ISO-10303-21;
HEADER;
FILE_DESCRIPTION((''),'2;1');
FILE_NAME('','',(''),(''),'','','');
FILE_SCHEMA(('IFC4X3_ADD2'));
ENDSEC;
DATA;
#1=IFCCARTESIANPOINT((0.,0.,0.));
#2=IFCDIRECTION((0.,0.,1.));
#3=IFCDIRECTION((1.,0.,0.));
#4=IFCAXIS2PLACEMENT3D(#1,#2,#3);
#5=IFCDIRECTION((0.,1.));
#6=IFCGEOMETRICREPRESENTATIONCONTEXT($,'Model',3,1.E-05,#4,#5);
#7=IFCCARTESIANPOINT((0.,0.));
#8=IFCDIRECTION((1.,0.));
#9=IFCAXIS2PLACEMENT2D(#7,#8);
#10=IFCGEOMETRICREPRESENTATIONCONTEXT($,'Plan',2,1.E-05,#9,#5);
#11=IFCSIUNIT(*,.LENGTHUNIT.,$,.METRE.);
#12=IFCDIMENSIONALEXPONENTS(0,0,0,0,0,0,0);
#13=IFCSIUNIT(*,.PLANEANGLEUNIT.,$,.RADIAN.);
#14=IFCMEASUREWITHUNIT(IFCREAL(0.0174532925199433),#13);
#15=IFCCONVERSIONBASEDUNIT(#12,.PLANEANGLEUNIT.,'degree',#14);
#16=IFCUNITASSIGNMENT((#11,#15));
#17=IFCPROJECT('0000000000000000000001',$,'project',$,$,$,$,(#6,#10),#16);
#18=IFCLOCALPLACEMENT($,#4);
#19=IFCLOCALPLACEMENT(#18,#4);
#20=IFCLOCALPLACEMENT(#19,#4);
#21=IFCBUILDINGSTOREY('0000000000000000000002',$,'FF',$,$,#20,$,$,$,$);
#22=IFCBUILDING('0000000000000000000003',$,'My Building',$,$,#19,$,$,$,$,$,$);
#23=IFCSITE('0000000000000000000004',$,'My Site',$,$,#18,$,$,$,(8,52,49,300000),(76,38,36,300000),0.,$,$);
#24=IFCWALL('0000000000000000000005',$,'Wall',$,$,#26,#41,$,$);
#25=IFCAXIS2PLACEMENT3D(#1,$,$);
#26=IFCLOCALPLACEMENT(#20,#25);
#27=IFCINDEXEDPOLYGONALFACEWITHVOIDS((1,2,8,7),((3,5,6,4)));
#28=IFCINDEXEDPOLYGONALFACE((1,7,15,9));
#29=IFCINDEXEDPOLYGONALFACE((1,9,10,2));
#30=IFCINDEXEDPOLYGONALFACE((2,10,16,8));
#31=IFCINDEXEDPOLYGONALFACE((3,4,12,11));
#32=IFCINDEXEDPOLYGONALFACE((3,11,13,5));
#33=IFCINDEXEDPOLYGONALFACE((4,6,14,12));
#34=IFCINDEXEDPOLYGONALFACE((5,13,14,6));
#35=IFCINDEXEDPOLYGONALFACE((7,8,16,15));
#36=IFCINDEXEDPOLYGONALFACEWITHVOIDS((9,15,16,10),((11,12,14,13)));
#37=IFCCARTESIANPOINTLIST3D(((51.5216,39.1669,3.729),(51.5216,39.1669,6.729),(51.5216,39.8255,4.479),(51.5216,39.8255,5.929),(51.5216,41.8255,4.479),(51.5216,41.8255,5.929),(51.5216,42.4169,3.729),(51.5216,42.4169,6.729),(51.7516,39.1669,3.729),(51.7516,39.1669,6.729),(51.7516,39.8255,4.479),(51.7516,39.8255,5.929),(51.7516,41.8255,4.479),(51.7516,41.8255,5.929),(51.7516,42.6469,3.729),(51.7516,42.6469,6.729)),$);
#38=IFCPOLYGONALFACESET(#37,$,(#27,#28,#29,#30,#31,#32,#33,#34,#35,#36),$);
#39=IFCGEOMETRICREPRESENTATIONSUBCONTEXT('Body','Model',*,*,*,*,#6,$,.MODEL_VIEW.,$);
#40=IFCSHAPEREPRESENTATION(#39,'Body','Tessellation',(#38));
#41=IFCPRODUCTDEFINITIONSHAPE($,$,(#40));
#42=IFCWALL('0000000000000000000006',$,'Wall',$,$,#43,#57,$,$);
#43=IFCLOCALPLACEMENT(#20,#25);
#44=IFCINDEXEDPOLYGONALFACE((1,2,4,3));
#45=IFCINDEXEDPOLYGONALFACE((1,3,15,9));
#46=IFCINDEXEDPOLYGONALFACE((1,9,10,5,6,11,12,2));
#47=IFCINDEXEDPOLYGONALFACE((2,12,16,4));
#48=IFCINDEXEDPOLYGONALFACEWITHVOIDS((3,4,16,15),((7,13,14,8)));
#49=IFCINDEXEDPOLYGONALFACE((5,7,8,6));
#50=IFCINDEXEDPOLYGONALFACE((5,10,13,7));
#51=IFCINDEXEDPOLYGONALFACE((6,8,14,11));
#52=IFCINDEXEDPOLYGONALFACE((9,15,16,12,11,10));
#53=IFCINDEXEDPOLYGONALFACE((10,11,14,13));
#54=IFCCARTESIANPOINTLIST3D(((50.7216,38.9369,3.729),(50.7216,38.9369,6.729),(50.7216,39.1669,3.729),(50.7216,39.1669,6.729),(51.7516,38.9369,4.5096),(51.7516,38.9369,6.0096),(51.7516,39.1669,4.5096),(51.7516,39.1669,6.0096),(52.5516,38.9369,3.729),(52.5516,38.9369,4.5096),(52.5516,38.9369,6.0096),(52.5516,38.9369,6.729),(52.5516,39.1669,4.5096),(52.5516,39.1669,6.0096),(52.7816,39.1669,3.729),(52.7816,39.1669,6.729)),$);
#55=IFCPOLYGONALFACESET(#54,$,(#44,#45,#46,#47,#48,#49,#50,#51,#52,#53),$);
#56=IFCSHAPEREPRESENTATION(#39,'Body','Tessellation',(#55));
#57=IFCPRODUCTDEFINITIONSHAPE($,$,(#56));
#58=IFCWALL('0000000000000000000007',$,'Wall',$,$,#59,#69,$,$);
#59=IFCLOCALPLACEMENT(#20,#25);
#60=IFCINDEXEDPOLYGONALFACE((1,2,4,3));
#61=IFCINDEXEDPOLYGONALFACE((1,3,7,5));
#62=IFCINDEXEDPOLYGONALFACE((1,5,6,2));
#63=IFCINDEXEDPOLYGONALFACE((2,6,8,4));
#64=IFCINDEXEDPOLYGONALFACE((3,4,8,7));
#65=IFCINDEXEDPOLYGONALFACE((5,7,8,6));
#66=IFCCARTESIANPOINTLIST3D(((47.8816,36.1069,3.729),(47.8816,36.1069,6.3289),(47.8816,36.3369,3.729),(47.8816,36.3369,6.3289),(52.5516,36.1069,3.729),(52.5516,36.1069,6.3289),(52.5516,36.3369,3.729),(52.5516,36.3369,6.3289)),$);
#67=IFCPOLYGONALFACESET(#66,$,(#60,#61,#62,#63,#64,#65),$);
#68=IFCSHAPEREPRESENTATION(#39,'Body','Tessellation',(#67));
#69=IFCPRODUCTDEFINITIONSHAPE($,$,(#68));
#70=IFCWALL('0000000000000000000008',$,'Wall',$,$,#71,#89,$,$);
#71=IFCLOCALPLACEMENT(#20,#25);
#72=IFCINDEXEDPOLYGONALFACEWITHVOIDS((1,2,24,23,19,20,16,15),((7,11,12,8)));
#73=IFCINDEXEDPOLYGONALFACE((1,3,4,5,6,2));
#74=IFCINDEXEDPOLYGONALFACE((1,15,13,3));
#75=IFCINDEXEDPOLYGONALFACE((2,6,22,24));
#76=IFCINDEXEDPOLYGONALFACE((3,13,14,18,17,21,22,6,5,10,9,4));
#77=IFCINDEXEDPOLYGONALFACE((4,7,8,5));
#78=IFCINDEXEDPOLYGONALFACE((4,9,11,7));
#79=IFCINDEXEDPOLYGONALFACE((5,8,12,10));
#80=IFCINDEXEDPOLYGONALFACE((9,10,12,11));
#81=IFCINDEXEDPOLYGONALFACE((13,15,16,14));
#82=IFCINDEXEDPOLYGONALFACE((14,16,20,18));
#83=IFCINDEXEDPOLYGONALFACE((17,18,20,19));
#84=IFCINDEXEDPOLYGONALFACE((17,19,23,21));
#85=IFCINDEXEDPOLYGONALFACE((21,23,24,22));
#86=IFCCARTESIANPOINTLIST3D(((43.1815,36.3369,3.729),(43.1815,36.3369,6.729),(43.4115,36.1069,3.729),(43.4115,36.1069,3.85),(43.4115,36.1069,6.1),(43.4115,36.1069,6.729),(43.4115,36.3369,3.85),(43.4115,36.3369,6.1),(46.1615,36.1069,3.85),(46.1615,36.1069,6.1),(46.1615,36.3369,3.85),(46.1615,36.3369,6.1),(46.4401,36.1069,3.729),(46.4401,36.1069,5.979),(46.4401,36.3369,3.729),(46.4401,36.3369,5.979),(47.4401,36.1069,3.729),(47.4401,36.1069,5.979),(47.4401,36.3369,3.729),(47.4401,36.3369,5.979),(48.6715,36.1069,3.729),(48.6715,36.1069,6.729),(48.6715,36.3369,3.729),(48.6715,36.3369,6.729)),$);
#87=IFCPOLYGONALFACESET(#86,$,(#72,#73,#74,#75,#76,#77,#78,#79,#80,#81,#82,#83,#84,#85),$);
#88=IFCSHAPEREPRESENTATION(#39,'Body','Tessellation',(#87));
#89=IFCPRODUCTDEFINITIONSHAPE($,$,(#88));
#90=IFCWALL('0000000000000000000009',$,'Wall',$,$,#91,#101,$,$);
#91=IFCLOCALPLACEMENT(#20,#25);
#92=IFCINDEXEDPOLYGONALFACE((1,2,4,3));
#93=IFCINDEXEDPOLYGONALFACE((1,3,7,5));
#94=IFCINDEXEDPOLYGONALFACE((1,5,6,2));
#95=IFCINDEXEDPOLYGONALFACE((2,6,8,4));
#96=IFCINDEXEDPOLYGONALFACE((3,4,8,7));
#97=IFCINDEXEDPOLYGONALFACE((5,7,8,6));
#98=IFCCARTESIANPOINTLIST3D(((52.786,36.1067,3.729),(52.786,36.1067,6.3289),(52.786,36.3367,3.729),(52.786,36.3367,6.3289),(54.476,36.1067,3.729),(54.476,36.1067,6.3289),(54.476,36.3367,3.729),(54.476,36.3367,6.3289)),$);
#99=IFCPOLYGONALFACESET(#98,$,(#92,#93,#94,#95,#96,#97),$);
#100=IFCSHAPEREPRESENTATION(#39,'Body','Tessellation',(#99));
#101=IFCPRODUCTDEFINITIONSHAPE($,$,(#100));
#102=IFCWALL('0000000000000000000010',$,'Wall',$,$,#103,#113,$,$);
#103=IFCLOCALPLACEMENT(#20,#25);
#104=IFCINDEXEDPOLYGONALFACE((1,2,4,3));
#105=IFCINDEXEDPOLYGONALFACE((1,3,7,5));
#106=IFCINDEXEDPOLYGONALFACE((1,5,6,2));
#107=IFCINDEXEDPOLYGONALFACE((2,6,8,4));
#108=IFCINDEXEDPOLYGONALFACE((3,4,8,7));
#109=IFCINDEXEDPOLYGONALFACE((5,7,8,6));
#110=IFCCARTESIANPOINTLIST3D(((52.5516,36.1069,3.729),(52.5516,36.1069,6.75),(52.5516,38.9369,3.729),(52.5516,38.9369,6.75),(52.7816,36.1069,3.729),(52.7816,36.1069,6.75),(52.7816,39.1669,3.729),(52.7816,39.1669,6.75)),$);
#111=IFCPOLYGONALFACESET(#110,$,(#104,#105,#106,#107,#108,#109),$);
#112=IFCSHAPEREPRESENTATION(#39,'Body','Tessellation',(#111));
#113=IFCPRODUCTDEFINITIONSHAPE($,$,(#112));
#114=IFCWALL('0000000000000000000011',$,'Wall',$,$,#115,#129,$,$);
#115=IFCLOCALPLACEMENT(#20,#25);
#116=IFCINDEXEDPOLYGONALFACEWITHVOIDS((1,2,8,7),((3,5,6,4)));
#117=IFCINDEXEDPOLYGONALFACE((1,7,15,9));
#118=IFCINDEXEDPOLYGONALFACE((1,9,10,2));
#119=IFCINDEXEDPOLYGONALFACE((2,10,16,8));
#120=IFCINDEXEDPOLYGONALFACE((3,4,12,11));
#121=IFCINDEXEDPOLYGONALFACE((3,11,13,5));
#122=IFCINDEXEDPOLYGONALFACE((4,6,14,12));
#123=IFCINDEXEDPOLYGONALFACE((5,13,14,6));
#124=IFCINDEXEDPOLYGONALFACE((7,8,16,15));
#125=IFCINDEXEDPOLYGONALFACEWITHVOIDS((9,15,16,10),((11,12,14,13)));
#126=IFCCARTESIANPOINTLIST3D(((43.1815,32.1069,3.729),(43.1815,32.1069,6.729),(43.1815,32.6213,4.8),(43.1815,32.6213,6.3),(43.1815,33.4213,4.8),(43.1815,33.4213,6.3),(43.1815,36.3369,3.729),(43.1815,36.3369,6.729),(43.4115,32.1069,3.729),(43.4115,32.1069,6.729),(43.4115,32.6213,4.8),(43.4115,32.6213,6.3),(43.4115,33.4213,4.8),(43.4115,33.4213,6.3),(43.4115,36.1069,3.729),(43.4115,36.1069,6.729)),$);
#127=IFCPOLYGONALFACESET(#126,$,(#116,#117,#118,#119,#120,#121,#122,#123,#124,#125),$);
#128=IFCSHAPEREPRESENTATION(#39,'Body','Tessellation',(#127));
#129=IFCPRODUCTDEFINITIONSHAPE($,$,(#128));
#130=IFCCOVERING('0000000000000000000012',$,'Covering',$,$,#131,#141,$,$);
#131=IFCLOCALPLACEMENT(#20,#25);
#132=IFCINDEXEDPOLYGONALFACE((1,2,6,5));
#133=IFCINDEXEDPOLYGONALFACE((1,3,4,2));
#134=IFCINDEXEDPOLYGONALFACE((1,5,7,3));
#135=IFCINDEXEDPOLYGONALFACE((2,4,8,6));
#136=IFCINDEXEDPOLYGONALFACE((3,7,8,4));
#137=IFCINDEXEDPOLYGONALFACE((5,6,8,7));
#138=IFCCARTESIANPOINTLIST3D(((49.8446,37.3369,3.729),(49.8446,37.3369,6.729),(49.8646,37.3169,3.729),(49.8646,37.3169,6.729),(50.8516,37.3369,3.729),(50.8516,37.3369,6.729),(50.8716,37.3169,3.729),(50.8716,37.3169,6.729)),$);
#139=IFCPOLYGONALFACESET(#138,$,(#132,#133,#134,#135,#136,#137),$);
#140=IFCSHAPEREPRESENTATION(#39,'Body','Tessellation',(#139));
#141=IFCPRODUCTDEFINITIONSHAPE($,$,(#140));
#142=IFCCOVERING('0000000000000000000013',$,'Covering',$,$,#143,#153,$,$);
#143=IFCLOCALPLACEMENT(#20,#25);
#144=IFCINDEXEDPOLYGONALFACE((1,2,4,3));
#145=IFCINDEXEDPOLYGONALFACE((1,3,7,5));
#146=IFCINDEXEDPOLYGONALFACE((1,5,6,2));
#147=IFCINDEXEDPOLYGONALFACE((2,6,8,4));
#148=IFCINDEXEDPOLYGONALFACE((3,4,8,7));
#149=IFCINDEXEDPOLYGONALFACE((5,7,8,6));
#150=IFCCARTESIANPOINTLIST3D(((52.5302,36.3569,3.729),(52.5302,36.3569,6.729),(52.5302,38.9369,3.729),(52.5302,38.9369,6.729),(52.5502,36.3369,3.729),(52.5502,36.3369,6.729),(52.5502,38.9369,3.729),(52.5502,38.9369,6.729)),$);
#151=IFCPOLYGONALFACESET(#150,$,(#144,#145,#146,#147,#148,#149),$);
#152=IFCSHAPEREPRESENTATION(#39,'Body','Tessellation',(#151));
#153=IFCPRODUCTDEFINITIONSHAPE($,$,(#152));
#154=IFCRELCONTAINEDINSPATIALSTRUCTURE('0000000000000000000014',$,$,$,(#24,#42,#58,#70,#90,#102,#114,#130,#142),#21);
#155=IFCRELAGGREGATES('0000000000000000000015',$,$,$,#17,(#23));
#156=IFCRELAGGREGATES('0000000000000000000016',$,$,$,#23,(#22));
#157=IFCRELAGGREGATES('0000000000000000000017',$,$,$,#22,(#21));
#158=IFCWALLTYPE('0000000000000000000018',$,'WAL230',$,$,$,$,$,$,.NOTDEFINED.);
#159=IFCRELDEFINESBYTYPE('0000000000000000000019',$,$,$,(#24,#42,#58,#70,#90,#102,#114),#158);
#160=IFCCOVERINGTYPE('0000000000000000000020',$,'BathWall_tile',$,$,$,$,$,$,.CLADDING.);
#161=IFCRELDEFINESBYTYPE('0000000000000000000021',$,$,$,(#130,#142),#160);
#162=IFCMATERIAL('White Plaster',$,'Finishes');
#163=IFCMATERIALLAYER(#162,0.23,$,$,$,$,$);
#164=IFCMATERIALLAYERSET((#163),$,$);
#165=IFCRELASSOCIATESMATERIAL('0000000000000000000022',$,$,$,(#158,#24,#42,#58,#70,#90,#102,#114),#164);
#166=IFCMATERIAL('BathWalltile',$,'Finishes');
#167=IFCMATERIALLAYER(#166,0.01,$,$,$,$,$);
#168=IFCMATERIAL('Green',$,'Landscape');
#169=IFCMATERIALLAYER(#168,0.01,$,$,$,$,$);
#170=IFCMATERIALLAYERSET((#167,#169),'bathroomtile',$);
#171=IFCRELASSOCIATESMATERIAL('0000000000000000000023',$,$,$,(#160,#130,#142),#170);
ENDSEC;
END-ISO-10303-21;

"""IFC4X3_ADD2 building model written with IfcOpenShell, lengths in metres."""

from ifc_helpers import new_model, entity, si_unit, converted_unit, direction, frame, origin_with_axes, origin_2d_with_axis, place, context, subcontext, project, spatial, line, indexed_curve, outline, extrude, source, transform, mapped, material, layer, layer_set, layer_usage, type_object, element, save


model = new_model("IFC4X3_ADD2")

# Units and contexts
model_context = context("Model", 3, precision=1e-05, world=origin_with_axes(), true_north=direction((0.0, 1.0)))
plan_context = context("Plan", 2, precision=1e-05, world=origin_2d_with_axis(), true_north=direction((0.0, 1.0)))
body_context_1 = subcontext(model_context, "Body", "Model", "MODEL_VIEW")
ifc_project = project(units=[si_unit("LENGTHUNIT", "METRE"), converted_unit("PLANEANGLEUNIT", "degree", entity("IfcReal", 0.0174532925199433), si_unit("PLANEANGLEUNIT", "RADIAN"), dimensions=[0, 0, 0, 0, 0, 0, 0])], contexts=[model_context, plan_context])

# Site, building, storey
site_placement = place(None, origin_with_axes())
site = spatial("IfcSite", under=ifc_project, at=site_placement, Name="My Site", RefLatitude=(8, 52, 49, 300000), RefLongitude=(76, 38, 36, 300000), RefElevation=0.0)
building_placement = place(site_placement, origin_with_axes())
building = spatial("IfcBuilding", under=site, at=building_placement, Name="My Building")
storey_placement = place(building_placement, origin_with_axes())
storey = spatial("IfcBuildingStorey", under=building, at=storey_placement, Name="FF")

# Walls, openings
ifc_material_1 = material(Name="White Plaster", Category="Finishes")
ifc_layer_1 = layer(ifc_material_1, 0.23)
ifc_layer_set_1 = layer_set([ifc_layer_1])
ifc_layer_usage_1 = layer_usage(ifc_layer_set_1, "AXIS2", "POSITIVE", 0.0)
wall_type_1 = type_object("IfcWallType", Name="WAL230", PredefinedType="NOTDEFINED", material=ifc_layer_set_1)
wall_1_placement = place(storey_placement, frame((51.7516, 39.1669, 3.729), z_axis=(0.0, 0.0, 1.0), x_axis=(0.0, 1.0, 0.0)))
wall_1 = element("IfcWall", 1, at=wall_1_placement, inside=storey, type_object=wall_type_1, material=ifc_layer_usage_1, Name="Wall", context=body_context_1, shape_type="SweptSolid", body=[
    extrude(outline(indexed_curve([(0.0, 0.0), (0.0, 0.23), (3.25, 0.23), (3.48, 0.0)], segments=[line(1, 2, 3, 4, 1)])), origin_with_axes(), (0.0, 0.0, 1.0), 3.0),
])
shared_shape_1 = source(origin_with_axes(), body_context_1, "Body", "SweptSolid", [
    extrude(outline(indexed_curve([(0.0, 0.0), (2.0, 0.0), (2.0, 1.45), (0.0, 1.45)], segments=[line(1, 2, 3, 4, 1)])), frame((0.0, -0.6, 0.0), z_axis=(0.0, -1.0, 0.0), x_axis=(1.0, 0.0, 0.0)), (0.0, 0.0, -1.0), 1.2),
])
opening_1_placement = place(wall_1_placement, frame((0.6586, 0.0, 0.75), z_axis=(0.0, 0.0, 1.0), x_axis=(1.0, 0.0, 0.0)))
element("IfcOpeningElement", 2, at=opening_1_placement, cuts=wall_1, PredefinedType="OPENING", context=body_context_1, shape_type="MappedRepresentation", body=[
    mapped(shared_shape_1, transform((0.0, 0.0, 0.0), x_axis=(1.0, 0.0, 0.0), y_axis=(0.0, 1.0, 0.0), z_axis=(0.0, 0.0, 1.0), scale=1.0)),
])
ifc_layer_usage_2 = layer_usage(ifc_layer_set_1, "AXIS2", "POSITIVE", 0.0)
wall_2_placement = place(storey_placement, frame((52.5516, 39.1669, 3.729), z_axis=(0.0, 0.0, 1.0), x_axis=(-1.0, 0.0, 0.0)))
wall_2 = element("IfcWall", 3, at=wall_2_placement, inside=storey, type_object=wall_type_1, material=ifc_layer_usage_2, Name="Wall", context=body_context_1, shape_type="SweptSolid", body=[
    extrude(outline(indexed_curve([(-0.23, 0.0), (0.0, 0.23), (1.83, 0.23), (1.83, 0.0)], segments=[line(1, 2, 3, 4, 1)])), origin_with_axes(), (0.0, 0.0, 1.0), 3.0),
])
shared_shape_2 = source(origin_with_axes(), body_context_1, "Body", "SweptSolid", [
    extrude(outline(indexed_curve([(0.0, 0.0), (0.8, 0.0), (0.8, 1.5), (0.0, 1.5)], segments=[line(1, 2, 3, 4, 1)])), frame((0.0, -0.6, 0.0), z_axis=(0.0, -1.0, 0.0), x_axis=(1.0, 0.0, 0.0)), (0.0, 0.0, -1.0), 1.2),
])
opening_2_placement = place(wall_2_placement, frame((0.8, 0.23, 0.7806), z_axis=(0.0, 0.0, 1.0), x_axis=(-1.0, 0.0, 0.0)))
element("IfcOpeningElement", 4, at=opening_2_placement, cuts=wall_2, PredefinedType="OPENING", context=body_context_1, shape_type="MappedRepresentation", body=[
    mapped(shared_shape_2, transform((0.0, 0.0, 0.0), x_axis=(1.0, 0.0, 0.0), y_axis=(0.0, 1.0, 0.0), z_axis=(0.0, 0.0, 1.0), scale=1.0)),
])

# Wall
ifc_layer_usage_3 = layer_usage(ifc_layer_set_1, "AXIS2", "NEGATIVE", 0.0)
wall_3_placement = place(storey_placement, frame((52.5516, 36.1069, 3.729), z_axis=(0.0, 0.0, 1.0), x_axis=(-1.0, 0.0, 0.0)))
element("IfcWall", 5, at=wall_3_placement, inside=storey, type_object=wall_type_1, material=ifc_layer_usage_3, Name="Wall", context=body_context_1, shape_type="SweptSolid", body=[
    extrude(outline(indexed_curve([(0.0, -0.23), (0.0, 0.0), (4.67, 0.0), (4.67, -0.23)], segments=[line(1, 2, 3, 4, 1)])), origin_with_axes(), (0.0, 0.0, 1.0), 2.5999),
])

# Wall, openings
ifc_layer_usage_4 = layer_usage(ifc_layer_set_1, "AXIS2", "POSITIVE", 0.0)
wall_4_placement = place(storey_placement, frame((48.6715, 36.3369, 3.729), z_axis=(0.0, 0.0, 1.0), x_axis=(-1.0, 0.0, 0.0)))
wall_4 = element("IfcWall", 6, at=wall_4_placement, inside=storey, type_object=wall_type_1, material=ifc_layer_usage_4, Name="Wall", context=body_context_1, shape_type="SweptSolid", body=[
    extrude(outline(indexed_curve([(0.0, 0.0), (0.0, 0.23), (5.26, 0.23), (5.49, 0.0)], segments=[line(1, 2, 3, 4, 1)])), origin_with_axes(), (0.0, 0.0, 1.0), 3.0),
])
shared_shape_3 = source(origin_with_axes(), body_context_1, "Body", "SweptSolid", [
    extrude(outline(indexed_curve([(0.0, 0.0), (1.0, 0.0), (1.0, 2.25), (0.0, 2.25)], segments=[line(1, 2, 3, 4, 1)])), frame((0.0, -0.6, 0.0), z_axis=(0.0, -1.0, 0.0), x_axis=(1.0, 0.0, 0.0)), (0.0, 0.0, -1.0), 1.2),
])
opening_3_placement = place(wall_4_placement, frame((2.2314, 0.23, 0.0), z_axis=(0.0, 0.0, 1.0), x_axis=(-1.0, 0.0, 0.0)))
element("IfcOpeningElement", 7, at=opening_3_placement, cuts=wall_4, PredefinedType="OPENING", context=body_context_1, shape_type="MappedRepresentation", body=[
    mapped(shared_shape_3, transform((0.0, 0.0, 0.0), x_axis=(1.0, 0.0, 0.0), y_axis=(0.0, 1.0, 0.0), z_axis=(0.0, 0.0, 1.0), scale=1.0)),
])
shared_shape_4 = source(origin_with_axes(), body_context_1, "Body", "SweptSolid", [
    extrude(outline(indexed_curve([(0.0, 0.0), (2.75, 0.0), (2.75, 2.25), (0.0, 2.25)], segments=[line(1, 2, 3, 4, 1)])), frame((0.0, -0.6, 0.0), z_axis=(0.0, -1.0, 0.0), x_axis=(1.0, 0.0, 0.0)), (0.0, 0.0, -1.0), 1.2),
])
opening_4_placement = place(wall_4_placement, frame((2.51, 0.0, 0.121), z_axis=(0.0, 0.0, 1.0), x_axis=(1.0, 0.0, 0.0)))
element("IfcOpeningElement", 8, at=opening_4_placement, cuts=wall_4, PredefinedType="OPENING", context=body_context_1, shape_type="MappedRepresentation", body=[
    mapped(shared_shape_4, transform((0.0, 0.0, 0.0), x_axis=(1.0, 0.0, 0.0), y_axis=(0.0, 1.0, 0.0), z_axis=(0.0, 0.0, 1.0), scale=1.0)),
])

# Walls
ifc_layer_usage_5 = layer_usage(ifc_layer_set_1, "AXIS2", "POSITIVE", 0.0)
wall_5_placement = place(storey_placement, frame((54.476, 36.3367, 3.729), z_axis=(0.0, 0.0, 1.0), x_axis=(-1.0, 0.0, 0.0)))
element("IfcWall", 9, at=wall_5_placement, inside=storey, type_object=wall_type_1, material=ifc_layer_usage_5, Name="Wall", context=body_context_1, shape_type="SweptSolid", body=[
    extrude(outline(indexed_curve([(0.0, 0.0), (0.0, 0.23), (1.69, 0.23), (1.69, 0.0)], segments=[line(1, 2, 3, 4, 1)])), origin_with_axes(), (0.0, 0.0, 1.0), 2.5999),
])
ifc_layer_usage_6 = layer_usage(ifc_layer_set_1, "AXIS2", "POSITIVE", 0.0)
wall_6_placement = place(storey_placement, frame((52.5516, 39.1669, 3.729), z_axis=(0.0, 0.0, 1.0), x_axis=(-0.000001, -1.0, 0.0)))
element("IfcWall", 10, at=wall_6_placement, inside=storey, type_object=wall_type_1, material=ifc_layer_usage_6, Name="Wall", context=body_context_1, shape_type="SweptSolid", body=[
    extrude(outline(indexed_curve([(0.23, 0.0), (0.0, 0.23), (3.06, 0.23), (3.06, 0.0)], segments=[line(1, 2, 3, 4, 1)])), origin_with_axes(), (0.0, 0.0, 1.0), 3.021),
])

# Wall, opening
ifc_layer_usage_7 = layer_usage(ifc_layer_set_1, "AXIS2", "POSITIVE", 0.0)
wall_7_placement = place(storey_placement, frame((43.4115, 32.1069, 3.729), z_axis=(0.0, 0.0, 1.0), x_axis=(0.0, 1.0, 0.0)))
wall_7 = element("IfcWall", 11, at=wall_7_placement, inside=storey, type_object=wall_type_1, material=ifc_layer_usage_7, Name="Wall", context=body_context_1, shape_type="SweptSolid", body=[
    extrude(outline(indexed_curve([(0.0, 0.0), (0.0, 0.23), (4.23, 0.23), (4.0, 0.0)], segments=[line(1, 2, 3, 4, 1)])), origin_with_axes(), (0.0, 0.0, 1.0), 3.0),
])
opening_5_placement = place(wall_7_placement, frame((0.5144, 0.0, 1.071), z_axis=(0.0, 0.0, 1.0), x_axis=(1.0, 0.0, 0.0)))
element("IfcOpeningElement", 12, at=opening_5_placement, cuts=wall_7, PredefinedType="OPENING", context=body_context_1, shape_type="MappedRepresentation", body=[
    mapped(shared_shape_2, transform((0.0, 0.0, 0.0), x_axis=(1.0, 0.0, 0.0), y_axis=(0.0, 1.0, 0.0), z_axis=(0.0, 0.0, 1.0), scale=1.0)),
])

# Coverings
ifc_material_2 = material(Name="BathWalltile", Category="Finishes")
ifc_layer_2 = layer(ifc_material_2, 0.01)
ifc_material_3 = material(Name="Green", Category="Landscape")
ifc_layer_3 = layer(ifc_material_3, 0.01)
ifc_layer_set_2 = layer_set([ifc_layer_2, ifc_layer_3], Name="bathroomtile")
ifc_layer_usage_8 = layer_usage(ifc_layer_set_2, "AXIS2", "POSITIVE", 0.0)
covering_type = type_object("IfcCoveringType", Name="BathWall_tile", PredefinedType="CLADDING", material=ifc_layer_set_2)
covering_1_placement = place(storey_placement, frame((49.8646, 37.3169, 3.729), z_axis=(0.0, 0.0, 1.0), x_axis=(1.0, 0.0, 0.0)))
element("IfcCovering", 13, at=covering_1_placement, inside=storey, type_object=covering_type, material=ifc_layer_usage_8, Name="Covering", context=body_context_1, shape_type="SweptSolid", body=[
    extrude(outline(indexed_curve([(0.0, 0.0), (-0.02, 0.02), (0.9871, 0.02), (1.0071, 0.0)], segments=[line(1, 2, 3, 4, 1)])), origin_with_axes(), (0.0, 0.0, 1.0), 3.0),
])
ifc_layer_usage_9 = layer_usage(ifc_layer_set_2, "AXIS2", "NEGATIVE", 0.0)
covering_2_placement = place(storey_placement, frame((52.5302, 36.3569, 3.729), z_axis=(0.0, 0.0, 1.0), x_axis=(0.0, 1.0, 0.0)))
element("IfcCovering", 14, at=covering_2_placement, inside=storey, type_object=covering_type, material=ifc_layer_usage_9, Name="Covering", context=body_context_1, shape_type="SweptSolid", body=[
    extrude(outline(indexed_curve([(-0.02, -0.02), (0.0, 0.0), (2.58, 0.0), (2.58, -0.02)], segments=[line(1, 2, 3, 4, 1)])), origin_with_axes(), (0.0, 0.0, 1.0), 3.0),
])

save(model, "model.ifc")
